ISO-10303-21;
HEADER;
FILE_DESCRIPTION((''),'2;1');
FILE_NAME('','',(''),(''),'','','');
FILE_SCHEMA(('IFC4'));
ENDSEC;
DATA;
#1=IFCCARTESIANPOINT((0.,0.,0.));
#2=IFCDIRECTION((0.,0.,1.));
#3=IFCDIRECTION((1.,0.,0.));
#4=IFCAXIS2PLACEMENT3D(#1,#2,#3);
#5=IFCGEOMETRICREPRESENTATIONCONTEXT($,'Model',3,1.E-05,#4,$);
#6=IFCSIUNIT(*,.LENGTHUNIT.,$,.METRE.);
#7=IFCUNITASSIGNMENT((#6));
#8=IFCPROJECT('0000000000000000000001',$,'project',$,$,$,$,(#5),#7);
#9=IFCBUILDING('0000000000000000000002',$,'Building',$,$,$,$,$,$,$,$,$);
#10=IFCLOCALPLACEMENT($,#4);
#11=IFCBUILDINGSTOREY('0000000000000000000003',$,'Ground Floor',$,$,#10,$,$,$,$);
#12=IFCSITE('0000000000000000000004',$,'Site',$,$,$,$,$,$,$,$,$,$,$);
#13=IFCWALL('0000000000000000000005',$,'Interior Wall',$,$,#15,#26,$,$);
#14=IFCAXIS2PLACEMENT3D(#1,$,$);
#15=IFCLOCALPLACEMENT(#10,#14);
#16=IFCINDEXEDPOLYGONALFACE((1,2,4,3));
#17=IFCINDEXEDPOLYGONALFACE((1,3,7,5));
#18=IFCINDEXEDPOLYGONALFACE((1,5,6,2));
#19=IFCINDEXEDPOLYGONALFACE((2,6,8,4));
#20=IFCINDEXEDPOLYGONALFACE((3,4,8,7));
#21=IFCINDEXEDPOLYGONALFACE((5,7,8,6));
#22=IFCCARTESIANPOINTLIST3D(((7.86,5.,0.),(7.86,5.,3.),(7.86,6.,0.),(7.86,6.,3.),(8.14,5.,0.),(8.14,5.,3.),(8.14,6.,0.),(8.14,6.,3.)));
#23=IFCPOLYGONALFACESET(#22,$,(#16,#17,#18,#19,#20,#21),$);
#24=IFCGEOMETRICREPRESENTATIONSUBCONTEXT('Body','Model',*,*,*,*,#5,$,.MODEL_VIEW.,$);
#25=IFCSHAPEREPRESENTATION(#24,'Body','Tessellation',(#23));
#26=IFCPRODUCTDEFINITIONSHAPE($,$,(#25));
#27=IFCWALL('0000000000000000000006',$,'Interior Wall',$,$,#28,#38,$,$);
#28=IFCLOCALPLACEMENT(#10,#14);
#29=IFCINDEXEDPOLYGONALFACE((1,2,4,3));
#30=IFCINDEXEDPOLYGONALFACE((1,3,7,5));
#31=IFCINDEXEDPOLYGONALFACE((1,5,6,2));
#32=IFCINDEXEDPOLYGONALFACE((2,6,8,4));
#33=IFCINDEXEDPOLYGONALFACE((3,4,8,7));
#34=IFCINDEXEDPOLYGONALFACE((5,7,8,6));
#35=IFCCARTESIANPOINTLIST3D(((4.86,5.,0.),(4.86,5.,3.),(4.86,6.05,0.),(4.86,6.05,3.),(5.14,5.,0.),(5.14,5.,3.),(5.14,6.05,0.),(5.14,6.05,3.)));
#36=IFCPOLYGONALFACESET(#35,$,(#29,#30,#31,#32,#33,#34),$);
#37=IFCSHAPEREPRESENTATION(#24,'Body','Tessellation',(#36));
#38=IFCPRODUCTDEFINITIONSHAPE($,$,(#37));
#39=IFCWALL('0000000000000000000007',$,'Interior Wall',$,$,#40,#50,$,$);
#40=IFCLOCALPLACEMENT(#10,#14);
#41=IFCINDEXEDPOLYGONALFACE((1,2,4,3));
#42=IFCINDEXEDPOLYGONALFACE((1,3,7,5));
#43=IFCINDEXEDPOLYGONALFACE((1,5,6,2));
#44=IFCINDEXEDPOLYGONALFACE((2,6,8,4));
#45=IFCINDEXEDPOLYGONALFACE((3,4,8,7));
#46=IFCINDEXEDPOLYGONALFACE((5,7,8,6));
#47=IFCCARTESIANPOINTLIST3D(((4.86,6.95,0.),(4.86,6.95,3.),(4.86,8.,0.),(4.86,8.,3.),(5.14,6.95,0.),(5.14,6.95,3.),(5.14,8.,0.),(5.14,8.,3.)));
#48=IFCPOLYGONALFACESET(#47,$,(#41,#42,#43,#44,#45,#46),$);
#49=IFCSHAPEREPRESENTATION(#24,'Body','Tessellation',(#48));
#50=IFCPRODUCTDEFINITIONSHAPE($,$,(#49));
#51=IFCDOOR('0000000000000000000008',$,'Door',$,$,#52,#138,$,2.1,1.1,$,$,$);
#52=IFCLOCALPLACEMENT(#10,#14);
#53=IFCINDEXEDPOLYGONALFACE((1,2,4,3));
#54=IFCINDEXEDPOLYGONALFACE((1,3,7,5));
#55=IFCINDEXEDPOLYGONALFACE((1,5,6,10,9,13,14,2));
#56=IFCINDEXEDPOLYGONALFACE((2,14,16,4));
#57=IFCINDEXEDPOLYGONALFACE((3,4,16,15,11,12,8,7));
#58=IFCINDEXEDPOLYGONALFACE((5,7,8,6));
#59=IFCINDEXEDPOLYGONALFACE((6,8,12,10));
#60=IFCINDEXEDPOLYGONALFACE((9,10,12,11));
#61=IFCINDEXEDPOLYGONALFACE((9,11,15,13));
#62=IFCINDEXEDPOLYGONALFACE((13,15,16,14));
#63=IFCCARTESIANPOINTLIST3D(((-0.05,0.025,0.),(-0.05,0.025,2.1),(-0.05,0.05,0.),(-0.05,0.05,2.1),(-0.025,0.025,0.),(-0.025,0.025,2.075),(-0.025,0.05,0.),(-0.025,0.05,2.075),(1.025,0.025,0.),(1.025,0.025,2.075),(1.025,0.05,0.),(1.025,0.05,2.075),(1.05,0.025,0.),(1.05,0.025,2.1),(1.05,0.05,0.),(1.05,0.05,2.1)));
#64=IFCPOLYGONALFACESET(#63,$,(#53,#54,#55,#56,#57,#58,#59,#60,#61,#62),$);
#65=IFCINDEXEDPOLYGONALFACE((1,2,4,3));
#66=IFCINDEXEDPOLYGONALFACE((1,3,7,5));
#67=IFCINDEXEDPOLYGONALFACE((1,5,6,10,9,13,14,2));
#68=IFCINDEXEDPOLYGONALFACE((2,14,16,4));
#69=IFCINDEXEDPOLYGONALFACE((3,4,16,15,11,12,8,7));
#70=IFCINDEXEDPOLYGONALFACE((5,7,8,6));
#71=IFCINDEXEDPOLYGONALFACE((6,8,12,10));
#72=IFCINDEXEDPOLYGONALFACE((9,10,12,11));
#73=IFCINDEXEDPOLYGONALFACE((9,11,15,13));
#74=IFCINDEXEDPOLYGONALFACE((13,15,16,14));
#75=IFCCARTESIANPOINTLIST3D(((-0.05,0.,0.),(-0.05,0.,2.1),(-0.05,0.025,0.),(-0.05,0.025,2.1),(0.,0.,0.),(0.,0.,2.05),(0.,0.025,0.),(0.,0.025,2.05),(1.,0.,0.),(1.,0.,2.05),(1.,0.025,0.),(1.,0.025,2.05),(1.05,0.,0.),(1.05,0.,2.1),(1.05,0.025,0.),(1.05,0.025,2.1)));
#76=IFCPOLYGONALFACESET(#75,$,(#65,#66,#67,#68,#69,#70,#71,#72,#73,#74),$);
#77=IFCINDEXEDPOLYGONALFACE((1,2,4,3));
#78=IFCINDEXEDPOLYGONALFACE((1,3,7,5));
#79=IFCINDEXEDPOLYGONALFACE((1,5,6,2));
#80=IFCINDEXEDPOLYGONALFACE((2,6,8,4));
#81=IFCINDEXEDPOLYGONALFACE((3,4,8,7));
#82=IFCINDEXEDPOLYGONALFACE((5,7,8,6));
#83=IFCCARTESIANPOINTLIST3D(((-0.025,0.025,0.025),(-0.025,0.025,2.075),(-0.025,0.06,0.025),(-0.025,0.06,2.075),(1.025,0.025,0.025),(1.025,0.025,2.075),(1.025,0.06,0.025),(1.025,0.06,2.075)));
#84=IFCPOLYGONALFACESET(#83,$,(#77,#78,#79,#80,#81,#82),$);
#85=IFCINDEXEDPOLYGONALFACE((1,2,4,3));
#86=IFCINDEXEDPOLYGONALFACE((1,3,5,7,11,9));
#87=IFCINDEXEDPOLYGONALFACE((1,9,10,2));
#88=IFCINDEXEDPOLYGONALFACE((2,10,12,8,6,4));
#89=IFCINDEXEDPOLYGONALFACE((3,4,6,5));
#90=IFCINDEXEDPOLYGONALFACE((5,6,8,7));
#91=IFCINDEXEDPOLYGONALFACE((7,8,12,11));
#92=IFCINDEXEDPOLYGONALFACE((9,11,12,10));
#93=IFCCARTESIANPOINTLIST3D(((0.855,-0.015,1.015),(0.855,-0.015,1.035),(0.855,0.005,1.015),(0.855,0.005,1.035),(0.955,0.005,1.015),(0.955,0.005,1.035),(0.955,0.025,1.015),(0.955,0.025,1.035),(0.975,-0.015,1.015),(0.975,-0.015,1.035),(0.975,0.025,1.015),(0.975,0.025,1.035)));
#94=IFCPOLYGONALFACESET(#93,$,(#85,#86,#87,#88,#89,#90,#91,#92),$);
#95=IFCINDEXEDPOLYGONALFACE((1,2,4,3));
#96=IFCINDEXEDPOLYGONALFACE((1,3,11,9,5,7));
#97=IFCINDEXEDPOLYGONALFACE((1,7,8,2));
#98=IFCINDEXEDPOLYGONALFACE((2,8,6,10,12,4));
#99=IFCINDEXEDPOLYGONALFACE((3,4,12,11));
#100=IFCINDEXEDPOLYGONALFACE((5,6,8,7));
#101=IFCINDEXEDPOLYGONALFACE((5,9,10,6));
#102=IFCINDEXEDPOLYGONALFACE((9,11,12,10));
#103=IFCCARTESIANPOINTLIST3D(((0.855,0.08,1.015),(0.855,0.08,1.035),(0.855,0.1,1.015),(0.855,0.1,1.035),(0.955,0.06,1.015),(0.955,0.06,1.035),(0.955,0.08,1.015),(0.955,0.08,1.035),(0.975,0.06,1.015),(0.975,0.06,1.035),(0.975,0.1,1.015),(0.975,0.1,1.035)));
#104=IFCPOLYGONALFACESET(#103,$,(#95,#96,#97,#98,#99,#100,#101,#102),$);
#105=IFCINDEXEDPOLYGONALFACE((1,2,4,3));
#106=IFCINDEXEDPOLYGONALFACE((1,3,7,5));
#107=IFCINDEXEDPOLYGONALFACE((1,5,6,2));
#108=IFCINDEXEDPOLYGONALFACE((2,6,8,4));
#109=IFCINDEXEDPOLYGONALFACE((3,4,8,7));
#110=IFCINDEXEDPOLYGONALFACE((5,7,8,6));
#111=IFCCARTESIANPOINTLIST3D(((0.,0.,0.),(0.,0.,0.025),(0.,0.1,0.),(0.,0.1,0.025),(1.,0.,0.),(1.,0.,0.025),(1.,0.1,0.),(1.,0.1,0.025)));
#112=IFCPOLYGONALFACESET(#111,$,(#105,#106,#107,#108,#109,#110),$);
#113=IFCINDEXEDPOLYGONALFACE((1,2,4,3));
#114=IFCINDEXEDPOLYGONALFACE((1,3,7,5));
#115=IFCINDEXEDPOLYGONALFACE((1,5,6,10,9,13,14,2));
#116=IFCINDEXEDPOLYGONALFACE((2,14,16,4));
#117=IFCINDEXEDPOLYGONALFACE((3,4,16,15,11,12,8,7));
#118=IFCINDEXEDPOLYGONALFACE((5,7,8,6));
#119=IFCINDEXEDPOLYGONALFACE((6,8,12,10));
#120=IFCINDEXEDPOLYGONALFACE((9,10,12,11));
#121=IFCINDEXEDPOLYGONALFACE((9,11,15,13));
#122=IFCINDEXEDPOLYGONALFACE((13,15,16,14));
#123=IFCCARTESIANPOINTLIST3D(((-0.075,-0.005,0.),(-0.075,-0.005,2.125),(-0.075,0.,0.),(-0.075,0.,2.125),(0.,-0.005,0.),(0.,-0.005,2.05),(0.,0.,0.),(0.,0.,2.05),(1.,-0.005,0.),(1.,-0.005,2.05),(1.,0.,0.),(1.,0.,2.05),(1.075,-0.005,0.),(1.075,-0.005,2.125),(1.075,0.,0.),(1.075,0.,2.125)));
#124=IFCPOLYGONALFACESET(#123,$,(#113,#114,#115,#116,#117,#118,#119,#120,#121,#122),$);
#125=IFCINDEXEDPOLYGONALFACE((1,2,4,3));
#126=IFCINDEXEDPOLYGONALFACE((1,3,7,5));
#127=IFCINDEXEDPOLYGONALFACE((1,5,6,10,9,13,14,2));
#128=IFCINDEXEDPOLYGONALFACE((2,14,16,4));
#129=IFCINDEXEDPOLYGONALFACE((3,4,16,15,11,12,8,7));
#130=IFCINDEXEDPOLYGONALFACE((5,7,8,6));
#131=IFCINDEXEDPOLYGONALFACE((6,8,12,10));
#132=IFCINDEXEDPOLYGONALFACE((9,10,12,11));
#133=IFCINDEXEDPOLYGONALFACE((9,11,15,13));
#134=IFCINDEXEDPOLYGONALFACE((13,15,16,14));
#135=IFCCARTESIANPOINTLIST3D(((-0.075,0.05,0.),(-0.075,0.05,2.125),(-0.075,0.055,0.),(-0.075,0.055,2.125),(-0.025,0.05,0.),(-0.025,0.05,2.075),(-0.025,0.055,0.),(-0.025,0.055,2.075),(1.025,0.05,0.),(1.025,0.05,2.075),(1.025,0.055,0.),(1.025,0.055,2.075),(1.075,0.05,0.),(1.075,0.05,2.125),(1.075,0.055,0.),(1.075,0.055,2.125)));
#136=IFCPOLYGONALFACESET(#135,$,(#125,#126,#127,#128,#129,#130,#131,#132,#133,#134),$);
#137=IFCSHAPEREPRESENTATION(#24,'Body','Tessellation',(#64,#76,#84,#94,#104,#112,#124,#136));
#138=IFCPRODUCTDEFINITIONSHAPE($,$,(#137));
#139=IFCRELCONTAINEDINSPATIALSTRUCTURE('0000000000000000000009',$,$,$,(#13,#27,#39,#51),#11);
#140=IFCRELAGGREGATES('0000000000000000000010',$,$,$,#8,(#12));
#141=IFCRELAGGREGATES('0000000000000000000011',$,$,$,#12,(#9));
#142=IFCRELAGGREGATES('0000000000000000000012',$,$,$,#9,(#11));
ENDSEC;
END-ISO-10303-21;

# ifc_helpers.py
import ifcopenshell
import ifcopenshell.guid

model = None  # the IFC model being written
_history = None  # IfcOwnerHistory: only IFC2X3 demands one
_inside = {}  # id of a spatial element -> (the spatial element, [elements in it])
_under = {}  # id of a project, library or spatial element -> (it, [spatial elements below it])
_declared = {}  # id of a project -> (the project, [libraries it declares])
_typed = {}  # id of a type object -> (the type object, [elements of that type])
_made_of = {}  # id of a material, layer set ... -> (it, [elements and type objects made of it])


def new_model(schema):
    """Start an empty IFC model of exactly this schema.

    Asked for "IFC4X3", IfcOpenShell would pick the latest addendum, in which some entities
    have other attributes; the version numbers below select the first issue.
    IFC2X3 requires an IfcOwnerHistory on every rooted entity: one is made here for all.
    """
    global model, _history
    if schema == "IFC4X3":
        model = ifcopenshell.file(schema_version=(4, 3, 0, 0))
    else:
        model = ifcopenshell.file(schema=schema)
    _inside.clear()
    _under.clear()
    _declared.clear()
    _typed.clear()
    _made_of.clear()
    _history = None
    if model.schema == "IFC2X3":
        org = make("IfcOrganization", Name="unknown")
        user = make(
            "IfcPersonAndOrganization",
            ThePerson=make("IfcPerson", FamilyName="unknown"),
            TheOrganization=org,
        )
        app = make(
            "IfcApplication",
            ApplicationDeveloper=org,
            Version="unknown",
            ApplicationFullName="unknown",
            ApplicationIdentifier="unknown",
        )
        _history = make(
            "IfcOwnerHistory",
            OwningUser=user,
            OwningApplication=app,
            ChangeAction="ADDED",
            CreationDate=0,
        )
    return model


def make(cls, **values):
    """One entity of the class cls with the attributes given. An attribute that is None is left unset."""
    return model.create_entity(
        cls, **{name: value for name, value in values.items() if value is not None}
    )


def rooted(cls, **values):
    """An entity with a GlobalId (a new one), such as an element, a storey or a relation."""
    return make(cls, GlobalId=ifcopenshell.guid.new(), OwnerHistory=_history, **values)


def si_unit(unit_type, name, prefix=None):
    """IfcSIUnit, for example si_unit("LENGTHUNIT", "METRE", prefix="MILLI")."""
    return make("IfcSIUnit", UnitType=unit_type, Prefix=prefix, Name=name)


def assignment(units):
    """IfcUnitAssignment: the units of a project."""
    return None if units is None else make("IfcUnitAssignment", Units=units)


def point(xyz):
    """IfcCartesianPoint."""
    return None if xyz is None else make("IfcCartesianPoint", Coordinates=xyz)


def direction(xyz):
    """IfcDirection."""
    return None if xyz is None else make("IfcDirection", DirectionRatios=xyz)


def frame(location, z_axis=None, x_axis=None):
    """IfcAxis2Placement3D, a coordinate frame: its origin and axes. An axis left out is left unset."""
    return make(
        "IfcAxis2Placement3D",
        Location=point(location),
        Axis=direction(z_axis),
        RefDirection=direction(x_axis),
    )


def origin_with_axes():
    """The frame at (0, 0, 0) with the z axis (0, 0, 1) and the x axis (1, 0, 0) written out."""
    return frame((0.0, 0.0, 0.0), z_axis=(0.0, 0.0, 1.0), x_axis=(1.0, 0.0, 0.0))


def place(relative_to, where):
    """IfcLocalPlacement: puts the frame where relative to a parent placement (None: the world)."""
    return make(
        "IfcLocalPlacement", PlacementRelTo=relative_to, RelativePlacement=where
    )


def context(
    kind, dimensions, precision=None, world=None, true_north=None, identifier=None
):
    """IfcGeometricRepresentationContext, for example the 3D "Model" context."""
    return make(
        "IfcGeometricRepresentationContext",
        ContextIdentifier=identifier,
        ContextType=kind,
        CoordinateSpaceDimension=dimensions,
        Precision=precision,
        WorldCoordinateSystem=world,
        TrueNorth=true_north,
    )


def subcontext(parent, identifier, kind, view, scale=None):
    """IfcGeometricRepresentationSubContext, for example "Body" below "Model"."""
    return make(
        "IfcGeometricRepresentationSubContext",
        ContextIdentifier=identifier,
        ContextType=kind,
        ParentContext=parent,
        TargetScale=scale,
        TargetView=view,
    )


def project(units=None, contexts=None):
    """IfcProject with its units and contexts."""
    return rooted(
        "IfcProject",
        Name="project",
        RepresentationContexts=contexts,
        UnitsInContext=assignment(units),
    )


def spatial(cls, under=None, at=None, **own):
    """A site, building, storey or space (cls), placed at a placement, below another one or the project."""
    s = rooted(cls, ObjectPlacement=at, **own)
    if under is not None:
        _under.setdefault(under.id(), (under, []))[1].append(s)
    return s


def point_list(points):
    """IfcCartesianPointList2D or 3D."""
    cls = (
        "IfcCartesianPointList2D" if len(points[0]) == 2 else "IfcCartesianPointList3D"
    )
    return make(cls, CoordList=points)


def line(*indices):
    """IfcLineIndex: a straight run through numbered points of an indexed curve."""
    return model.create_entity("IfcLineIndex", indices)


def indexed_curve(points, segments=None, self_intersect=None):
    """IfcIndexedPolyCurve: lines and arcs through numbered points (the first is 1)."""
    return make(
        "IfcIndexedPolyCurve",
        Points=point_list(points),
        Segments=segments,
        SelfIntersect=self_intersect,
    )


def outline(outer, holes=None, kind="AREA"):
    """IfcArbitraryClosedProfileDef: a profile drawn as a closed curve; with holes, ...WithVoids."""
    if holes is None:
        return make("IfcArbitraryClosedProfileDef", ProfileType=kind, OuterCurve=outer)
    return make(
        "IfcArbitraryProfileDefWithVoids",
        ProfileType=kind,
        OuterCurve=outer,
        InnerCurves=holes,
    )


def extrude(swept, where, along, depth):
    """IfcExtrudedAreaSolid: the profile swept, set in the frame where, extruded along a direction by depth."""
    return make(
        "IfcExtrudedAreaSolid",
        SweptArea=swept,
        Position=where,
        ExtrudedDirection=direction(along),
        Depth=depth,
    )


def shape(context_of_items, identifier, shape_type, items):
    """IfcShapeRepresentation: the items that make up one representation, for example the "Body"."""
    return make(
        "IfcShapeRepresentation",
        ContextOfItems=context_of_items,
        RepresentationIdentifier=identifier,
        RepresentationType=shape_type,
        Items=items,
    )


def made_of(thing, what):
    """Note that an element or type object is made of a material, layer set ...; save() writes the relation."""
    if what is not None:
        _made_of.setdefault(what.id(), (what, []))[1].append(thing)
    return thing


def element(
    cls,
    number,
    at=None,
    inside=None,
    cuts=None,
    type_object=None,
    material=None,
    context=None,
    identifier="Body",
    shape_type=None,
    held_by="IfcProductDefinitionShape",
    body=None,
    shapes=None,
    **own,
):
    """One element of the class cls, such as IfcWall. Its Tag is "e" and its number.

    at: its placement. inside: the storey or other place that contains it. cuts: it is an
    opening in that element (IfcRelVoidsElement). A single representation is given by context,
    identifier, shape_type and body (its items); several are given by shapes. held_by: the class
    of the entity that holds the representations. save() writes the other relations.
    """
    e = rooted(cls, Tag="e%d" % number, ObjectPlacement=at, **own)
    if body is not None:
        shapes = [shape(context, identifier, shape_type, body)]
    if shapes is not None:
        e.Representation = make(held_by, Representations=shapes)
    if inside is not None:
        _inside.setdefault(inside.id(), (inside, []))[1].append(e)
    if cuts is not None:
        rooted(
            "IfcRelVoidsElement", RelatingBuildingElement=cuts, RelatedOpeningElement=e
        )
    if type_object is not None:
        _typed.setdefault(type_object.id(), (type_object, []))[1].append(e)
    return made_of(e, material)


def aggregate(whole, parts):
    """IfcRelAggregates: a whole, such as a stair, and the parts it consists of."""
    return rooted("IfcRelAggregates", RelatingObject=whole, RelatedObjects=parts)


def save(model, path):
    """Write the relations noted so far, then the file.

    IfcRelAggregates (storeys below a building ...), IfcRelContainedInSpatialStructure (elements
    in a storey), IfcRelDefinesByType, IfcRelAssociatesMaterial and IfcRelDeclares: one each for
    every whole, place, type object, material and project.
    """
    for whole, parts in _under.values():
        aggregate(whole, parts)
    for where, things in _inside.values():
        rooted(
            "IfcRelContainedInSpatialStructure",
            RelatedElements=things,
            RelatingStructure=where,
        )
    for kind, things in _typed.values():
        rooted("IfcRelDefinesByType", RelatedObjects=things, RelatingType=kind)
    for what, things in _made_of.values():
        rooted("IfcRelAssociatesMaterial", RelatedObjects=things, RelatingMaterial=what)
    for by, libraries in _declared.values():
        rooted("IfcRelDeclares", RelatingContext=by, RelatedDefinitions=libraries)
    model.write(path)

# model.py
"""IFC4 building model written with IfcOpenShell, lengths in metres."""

from ifc_helpers import new_model, si_unit, frame, origin_with_axes, place, context, subcontext, project, spatial, line, indexed_curve, outline, extrude, element, save


model = new_model("IFC4")

# Units and contexts
model_context = context("Model", 3, precision=1e-05, world=origin_with_axes())
body_context = subcontext(model_context, "Body", "Model", "MODEL_VIEW")
ifc_project = project(units=[si_unit("LENGTHUNIT", "METRE")], contexts=[model_context])

# Site, building, storey
site = spatial("IfcSite", under=ifc_project, Name="Site")
building = spatial("IfcBuilding", under=site, Name="Building")
storey_placement = place(None, origin_with_axes())
storey = spatial("IfcBuildingStorey", under=building, at=storey_placement, Name="Ground Floor")

# Walls
wall_1_placement = place(storey_placement, frame((8.0, 6.0, 0.0), z_axis=(0.0, 0.0, 1.0), x_axis=(0.0, -1.0, 0.0)))
element("IfcWall", 1, at=wall_1_placement, inside=storey, Name="Interior Wall", context=body_context, shape_type="SweptSolid", body=[
    extrude(outline(indexed_curve([(0.0, 0.0), (0.0, 0.28), (1.0, 0.28), (1.0, 0.0), (0.0, 0.0)], self_intersect=False)), frame((0.0, -0.14, 0.0), z_axis=(0.0, 0.0, 1.0), x_axis=(1.0, 0.0, 0.0)), (0.0, 0.0, 1.0), 3.0),
])
for number, where, z_axis, x_axis, name in (
    (2, (5.0, 5.0, 0.0), (0.0, 0.0, 1.0), (0.0, 1.0, 0.0), "Interior Wall"),
    (3, (5.0, 6.95, 0.0), (0.0, 0.0, 1.0), (0.0, 1.0, 0.0), "Interior Wall"),
):
    element("IfcWall", number, at=place(storey_placement, frame(where, z_axis=z_axis, x_axis=x_axis)), inside=storey, Name=name, context=body_context, shape_type="SweptSolid", body=[
        extrude(outline(indexed_curve([(0.0, 0.0), (0.0, 0.28), (1.05, 0.28), (1.05, 0.0), (0.0, 0.0)], self_intersect=False)), frame((0.0, -0.14, 0.0), z_axis=(0.0, 0.0, 1.0), x_axis=(1.0, 0.0, 0.0)), (0.0, 0.0, 1.0), 3.0),
    ])

# Door
door_1_placement = place(storey_placement, frame((-0.05, 0.0, 0.0), z_axis=(0.0, 0.0, 1.0), x_axis=(1.0, 0.0, 0.0)))
element("IfcDoor", 4, at=door_1_placement, inside=storey, Name="Door", OverallHeight=2.1, OverallWidth=1.1, context=body_context, shape_type="SweptSolid", body=[
    extrude(outline(indexed_curve([(0.0, 0.0), (0.0, 2.1), (1.1, 2.1), (1.1, 0.0), (1.075, 0.0), (1.075, 2.075), (0.025, 2.075), (0.025, 0.0)], segments=[line(1, 2, 3, 4, 5, 6, 7, 8, 1)])), frame((0.0, 0.025, 0.0), z_axis=(0.0, -1.0, 0.0), x_axis=(1.0, 0.0, 0.0)), (0.0, 0.0, -1.0), 0.025),
    extrude(outline(indexed_curve([(0.0, 0.0), (0.0, 2.1), (1.1, 2.1), (1.1, 0.0), (1.05, 0.0), (1.05, 2.05), (0.05, 2.05), (0.05, 0.0)], segments=[line(1, 2, 3, 4, 5, 6, 7, 8, 1)])), frame((0.0, 0.0, 0.0), z_axis=(0.0, -1.0, 0.0), x_axis=(1.0, 0.0, 0.0)), (0.0, 0.0, -1.0), 0.025),
    extrude(outline(indexed_curve([(0.0, 0.0), (1.05, 0.0), (1.05, 0.035), (0.0, 0.035)], segments=[line(1, 2, 3, 4, 1)])), frame((0.025, 0.025, 0.025), z_axis=(0.0, 0.0, 1.0), x_axis=(1.0, 0.0, 0.0)), (0.0, 0.0, 1.0), 2.05),
    extrude(outline(indexed_curve([(0.0, 0.0), (0.0, -0.04), (-0.12, -0.04), (-0.12, -0.02), (-0.02, -0.02), (-0.02, 0.0)], segments=[line(1, 2, 3, 4, 5, 6, 1)])), frame((1.025, 0.025, 1.015), z_axis=(0.0, 0.0, 1.0), x_axis=(1.0, 0.0, 0.0)), (0.0, 0.0, 1.0), 0.02),
    extrude(outline(indexed_curve([(0.0, 0.0), (0.0, 0.04), (-0.12, 0.04), (-0.12, 0.02), (-0.02, 0.02), (-0.02, 0.0)], segments=[line(1, 2, 3, 4, 5, 6, 1)])), frame((1.025, 0.06, 1.015), z_axis=(0.0, 0.0, 1.0), x_axis=(1.0, 0.0, 0.0)), (0.0, 0.0, 1.0), 0.02),
    extrude(outline(indexed_curve([(0.0, 0.0), (1.0, 0.0), (1.0, 0.1), (0.0, 0.1)], segments=[line(1, 2, 3, 4, 1)])), frame((0.05, 0.0, 0.0), z_axis=(0.0, 0.0, 1.0), x_axis=(1.0, 0.0, 0.0)), (0.0, 0.0, 1.0), 0.025),
    extrude(outline(indexed_curve([(0.0, 0.0), (0.0, 2.125), (1.15, 2.125), (1.15, 0.0), (1.075, 0.0), (1.075, 2.05), (0.075, 2.05), (0.075, 0.0)], segments=[line(1, 2, 3, 4, 5, 6, 7, 8, 1)])), frame((-0.025, -0.005, 0.0), z_axis=(0.0, -1.0, 0.0), x_axis=(1.0, 0.0, 0.0)), (0.0, 0.0, -1.0), 0.005),
    extrude(outline(indexed_curve([(0.0, 0.0), (0.0, 2.125), (1.15, 2.125), (1.15, 0.0), (1.1, 0.0), (1.1, 2.075), (0.05, 2.075), (0.05, 0.0)], segments=[line(1, 2, 3, 4, 5, 6, 7, 8, 1)])), frame((-0.025, 0.05, 0.0), z_axis=(0.0, -1.0, 0.0), x_axis=(1.0, 0.0, 0.0)), (0.0, 0.0, -1.0), 0.005),
])

save(model, "model.ifc")
